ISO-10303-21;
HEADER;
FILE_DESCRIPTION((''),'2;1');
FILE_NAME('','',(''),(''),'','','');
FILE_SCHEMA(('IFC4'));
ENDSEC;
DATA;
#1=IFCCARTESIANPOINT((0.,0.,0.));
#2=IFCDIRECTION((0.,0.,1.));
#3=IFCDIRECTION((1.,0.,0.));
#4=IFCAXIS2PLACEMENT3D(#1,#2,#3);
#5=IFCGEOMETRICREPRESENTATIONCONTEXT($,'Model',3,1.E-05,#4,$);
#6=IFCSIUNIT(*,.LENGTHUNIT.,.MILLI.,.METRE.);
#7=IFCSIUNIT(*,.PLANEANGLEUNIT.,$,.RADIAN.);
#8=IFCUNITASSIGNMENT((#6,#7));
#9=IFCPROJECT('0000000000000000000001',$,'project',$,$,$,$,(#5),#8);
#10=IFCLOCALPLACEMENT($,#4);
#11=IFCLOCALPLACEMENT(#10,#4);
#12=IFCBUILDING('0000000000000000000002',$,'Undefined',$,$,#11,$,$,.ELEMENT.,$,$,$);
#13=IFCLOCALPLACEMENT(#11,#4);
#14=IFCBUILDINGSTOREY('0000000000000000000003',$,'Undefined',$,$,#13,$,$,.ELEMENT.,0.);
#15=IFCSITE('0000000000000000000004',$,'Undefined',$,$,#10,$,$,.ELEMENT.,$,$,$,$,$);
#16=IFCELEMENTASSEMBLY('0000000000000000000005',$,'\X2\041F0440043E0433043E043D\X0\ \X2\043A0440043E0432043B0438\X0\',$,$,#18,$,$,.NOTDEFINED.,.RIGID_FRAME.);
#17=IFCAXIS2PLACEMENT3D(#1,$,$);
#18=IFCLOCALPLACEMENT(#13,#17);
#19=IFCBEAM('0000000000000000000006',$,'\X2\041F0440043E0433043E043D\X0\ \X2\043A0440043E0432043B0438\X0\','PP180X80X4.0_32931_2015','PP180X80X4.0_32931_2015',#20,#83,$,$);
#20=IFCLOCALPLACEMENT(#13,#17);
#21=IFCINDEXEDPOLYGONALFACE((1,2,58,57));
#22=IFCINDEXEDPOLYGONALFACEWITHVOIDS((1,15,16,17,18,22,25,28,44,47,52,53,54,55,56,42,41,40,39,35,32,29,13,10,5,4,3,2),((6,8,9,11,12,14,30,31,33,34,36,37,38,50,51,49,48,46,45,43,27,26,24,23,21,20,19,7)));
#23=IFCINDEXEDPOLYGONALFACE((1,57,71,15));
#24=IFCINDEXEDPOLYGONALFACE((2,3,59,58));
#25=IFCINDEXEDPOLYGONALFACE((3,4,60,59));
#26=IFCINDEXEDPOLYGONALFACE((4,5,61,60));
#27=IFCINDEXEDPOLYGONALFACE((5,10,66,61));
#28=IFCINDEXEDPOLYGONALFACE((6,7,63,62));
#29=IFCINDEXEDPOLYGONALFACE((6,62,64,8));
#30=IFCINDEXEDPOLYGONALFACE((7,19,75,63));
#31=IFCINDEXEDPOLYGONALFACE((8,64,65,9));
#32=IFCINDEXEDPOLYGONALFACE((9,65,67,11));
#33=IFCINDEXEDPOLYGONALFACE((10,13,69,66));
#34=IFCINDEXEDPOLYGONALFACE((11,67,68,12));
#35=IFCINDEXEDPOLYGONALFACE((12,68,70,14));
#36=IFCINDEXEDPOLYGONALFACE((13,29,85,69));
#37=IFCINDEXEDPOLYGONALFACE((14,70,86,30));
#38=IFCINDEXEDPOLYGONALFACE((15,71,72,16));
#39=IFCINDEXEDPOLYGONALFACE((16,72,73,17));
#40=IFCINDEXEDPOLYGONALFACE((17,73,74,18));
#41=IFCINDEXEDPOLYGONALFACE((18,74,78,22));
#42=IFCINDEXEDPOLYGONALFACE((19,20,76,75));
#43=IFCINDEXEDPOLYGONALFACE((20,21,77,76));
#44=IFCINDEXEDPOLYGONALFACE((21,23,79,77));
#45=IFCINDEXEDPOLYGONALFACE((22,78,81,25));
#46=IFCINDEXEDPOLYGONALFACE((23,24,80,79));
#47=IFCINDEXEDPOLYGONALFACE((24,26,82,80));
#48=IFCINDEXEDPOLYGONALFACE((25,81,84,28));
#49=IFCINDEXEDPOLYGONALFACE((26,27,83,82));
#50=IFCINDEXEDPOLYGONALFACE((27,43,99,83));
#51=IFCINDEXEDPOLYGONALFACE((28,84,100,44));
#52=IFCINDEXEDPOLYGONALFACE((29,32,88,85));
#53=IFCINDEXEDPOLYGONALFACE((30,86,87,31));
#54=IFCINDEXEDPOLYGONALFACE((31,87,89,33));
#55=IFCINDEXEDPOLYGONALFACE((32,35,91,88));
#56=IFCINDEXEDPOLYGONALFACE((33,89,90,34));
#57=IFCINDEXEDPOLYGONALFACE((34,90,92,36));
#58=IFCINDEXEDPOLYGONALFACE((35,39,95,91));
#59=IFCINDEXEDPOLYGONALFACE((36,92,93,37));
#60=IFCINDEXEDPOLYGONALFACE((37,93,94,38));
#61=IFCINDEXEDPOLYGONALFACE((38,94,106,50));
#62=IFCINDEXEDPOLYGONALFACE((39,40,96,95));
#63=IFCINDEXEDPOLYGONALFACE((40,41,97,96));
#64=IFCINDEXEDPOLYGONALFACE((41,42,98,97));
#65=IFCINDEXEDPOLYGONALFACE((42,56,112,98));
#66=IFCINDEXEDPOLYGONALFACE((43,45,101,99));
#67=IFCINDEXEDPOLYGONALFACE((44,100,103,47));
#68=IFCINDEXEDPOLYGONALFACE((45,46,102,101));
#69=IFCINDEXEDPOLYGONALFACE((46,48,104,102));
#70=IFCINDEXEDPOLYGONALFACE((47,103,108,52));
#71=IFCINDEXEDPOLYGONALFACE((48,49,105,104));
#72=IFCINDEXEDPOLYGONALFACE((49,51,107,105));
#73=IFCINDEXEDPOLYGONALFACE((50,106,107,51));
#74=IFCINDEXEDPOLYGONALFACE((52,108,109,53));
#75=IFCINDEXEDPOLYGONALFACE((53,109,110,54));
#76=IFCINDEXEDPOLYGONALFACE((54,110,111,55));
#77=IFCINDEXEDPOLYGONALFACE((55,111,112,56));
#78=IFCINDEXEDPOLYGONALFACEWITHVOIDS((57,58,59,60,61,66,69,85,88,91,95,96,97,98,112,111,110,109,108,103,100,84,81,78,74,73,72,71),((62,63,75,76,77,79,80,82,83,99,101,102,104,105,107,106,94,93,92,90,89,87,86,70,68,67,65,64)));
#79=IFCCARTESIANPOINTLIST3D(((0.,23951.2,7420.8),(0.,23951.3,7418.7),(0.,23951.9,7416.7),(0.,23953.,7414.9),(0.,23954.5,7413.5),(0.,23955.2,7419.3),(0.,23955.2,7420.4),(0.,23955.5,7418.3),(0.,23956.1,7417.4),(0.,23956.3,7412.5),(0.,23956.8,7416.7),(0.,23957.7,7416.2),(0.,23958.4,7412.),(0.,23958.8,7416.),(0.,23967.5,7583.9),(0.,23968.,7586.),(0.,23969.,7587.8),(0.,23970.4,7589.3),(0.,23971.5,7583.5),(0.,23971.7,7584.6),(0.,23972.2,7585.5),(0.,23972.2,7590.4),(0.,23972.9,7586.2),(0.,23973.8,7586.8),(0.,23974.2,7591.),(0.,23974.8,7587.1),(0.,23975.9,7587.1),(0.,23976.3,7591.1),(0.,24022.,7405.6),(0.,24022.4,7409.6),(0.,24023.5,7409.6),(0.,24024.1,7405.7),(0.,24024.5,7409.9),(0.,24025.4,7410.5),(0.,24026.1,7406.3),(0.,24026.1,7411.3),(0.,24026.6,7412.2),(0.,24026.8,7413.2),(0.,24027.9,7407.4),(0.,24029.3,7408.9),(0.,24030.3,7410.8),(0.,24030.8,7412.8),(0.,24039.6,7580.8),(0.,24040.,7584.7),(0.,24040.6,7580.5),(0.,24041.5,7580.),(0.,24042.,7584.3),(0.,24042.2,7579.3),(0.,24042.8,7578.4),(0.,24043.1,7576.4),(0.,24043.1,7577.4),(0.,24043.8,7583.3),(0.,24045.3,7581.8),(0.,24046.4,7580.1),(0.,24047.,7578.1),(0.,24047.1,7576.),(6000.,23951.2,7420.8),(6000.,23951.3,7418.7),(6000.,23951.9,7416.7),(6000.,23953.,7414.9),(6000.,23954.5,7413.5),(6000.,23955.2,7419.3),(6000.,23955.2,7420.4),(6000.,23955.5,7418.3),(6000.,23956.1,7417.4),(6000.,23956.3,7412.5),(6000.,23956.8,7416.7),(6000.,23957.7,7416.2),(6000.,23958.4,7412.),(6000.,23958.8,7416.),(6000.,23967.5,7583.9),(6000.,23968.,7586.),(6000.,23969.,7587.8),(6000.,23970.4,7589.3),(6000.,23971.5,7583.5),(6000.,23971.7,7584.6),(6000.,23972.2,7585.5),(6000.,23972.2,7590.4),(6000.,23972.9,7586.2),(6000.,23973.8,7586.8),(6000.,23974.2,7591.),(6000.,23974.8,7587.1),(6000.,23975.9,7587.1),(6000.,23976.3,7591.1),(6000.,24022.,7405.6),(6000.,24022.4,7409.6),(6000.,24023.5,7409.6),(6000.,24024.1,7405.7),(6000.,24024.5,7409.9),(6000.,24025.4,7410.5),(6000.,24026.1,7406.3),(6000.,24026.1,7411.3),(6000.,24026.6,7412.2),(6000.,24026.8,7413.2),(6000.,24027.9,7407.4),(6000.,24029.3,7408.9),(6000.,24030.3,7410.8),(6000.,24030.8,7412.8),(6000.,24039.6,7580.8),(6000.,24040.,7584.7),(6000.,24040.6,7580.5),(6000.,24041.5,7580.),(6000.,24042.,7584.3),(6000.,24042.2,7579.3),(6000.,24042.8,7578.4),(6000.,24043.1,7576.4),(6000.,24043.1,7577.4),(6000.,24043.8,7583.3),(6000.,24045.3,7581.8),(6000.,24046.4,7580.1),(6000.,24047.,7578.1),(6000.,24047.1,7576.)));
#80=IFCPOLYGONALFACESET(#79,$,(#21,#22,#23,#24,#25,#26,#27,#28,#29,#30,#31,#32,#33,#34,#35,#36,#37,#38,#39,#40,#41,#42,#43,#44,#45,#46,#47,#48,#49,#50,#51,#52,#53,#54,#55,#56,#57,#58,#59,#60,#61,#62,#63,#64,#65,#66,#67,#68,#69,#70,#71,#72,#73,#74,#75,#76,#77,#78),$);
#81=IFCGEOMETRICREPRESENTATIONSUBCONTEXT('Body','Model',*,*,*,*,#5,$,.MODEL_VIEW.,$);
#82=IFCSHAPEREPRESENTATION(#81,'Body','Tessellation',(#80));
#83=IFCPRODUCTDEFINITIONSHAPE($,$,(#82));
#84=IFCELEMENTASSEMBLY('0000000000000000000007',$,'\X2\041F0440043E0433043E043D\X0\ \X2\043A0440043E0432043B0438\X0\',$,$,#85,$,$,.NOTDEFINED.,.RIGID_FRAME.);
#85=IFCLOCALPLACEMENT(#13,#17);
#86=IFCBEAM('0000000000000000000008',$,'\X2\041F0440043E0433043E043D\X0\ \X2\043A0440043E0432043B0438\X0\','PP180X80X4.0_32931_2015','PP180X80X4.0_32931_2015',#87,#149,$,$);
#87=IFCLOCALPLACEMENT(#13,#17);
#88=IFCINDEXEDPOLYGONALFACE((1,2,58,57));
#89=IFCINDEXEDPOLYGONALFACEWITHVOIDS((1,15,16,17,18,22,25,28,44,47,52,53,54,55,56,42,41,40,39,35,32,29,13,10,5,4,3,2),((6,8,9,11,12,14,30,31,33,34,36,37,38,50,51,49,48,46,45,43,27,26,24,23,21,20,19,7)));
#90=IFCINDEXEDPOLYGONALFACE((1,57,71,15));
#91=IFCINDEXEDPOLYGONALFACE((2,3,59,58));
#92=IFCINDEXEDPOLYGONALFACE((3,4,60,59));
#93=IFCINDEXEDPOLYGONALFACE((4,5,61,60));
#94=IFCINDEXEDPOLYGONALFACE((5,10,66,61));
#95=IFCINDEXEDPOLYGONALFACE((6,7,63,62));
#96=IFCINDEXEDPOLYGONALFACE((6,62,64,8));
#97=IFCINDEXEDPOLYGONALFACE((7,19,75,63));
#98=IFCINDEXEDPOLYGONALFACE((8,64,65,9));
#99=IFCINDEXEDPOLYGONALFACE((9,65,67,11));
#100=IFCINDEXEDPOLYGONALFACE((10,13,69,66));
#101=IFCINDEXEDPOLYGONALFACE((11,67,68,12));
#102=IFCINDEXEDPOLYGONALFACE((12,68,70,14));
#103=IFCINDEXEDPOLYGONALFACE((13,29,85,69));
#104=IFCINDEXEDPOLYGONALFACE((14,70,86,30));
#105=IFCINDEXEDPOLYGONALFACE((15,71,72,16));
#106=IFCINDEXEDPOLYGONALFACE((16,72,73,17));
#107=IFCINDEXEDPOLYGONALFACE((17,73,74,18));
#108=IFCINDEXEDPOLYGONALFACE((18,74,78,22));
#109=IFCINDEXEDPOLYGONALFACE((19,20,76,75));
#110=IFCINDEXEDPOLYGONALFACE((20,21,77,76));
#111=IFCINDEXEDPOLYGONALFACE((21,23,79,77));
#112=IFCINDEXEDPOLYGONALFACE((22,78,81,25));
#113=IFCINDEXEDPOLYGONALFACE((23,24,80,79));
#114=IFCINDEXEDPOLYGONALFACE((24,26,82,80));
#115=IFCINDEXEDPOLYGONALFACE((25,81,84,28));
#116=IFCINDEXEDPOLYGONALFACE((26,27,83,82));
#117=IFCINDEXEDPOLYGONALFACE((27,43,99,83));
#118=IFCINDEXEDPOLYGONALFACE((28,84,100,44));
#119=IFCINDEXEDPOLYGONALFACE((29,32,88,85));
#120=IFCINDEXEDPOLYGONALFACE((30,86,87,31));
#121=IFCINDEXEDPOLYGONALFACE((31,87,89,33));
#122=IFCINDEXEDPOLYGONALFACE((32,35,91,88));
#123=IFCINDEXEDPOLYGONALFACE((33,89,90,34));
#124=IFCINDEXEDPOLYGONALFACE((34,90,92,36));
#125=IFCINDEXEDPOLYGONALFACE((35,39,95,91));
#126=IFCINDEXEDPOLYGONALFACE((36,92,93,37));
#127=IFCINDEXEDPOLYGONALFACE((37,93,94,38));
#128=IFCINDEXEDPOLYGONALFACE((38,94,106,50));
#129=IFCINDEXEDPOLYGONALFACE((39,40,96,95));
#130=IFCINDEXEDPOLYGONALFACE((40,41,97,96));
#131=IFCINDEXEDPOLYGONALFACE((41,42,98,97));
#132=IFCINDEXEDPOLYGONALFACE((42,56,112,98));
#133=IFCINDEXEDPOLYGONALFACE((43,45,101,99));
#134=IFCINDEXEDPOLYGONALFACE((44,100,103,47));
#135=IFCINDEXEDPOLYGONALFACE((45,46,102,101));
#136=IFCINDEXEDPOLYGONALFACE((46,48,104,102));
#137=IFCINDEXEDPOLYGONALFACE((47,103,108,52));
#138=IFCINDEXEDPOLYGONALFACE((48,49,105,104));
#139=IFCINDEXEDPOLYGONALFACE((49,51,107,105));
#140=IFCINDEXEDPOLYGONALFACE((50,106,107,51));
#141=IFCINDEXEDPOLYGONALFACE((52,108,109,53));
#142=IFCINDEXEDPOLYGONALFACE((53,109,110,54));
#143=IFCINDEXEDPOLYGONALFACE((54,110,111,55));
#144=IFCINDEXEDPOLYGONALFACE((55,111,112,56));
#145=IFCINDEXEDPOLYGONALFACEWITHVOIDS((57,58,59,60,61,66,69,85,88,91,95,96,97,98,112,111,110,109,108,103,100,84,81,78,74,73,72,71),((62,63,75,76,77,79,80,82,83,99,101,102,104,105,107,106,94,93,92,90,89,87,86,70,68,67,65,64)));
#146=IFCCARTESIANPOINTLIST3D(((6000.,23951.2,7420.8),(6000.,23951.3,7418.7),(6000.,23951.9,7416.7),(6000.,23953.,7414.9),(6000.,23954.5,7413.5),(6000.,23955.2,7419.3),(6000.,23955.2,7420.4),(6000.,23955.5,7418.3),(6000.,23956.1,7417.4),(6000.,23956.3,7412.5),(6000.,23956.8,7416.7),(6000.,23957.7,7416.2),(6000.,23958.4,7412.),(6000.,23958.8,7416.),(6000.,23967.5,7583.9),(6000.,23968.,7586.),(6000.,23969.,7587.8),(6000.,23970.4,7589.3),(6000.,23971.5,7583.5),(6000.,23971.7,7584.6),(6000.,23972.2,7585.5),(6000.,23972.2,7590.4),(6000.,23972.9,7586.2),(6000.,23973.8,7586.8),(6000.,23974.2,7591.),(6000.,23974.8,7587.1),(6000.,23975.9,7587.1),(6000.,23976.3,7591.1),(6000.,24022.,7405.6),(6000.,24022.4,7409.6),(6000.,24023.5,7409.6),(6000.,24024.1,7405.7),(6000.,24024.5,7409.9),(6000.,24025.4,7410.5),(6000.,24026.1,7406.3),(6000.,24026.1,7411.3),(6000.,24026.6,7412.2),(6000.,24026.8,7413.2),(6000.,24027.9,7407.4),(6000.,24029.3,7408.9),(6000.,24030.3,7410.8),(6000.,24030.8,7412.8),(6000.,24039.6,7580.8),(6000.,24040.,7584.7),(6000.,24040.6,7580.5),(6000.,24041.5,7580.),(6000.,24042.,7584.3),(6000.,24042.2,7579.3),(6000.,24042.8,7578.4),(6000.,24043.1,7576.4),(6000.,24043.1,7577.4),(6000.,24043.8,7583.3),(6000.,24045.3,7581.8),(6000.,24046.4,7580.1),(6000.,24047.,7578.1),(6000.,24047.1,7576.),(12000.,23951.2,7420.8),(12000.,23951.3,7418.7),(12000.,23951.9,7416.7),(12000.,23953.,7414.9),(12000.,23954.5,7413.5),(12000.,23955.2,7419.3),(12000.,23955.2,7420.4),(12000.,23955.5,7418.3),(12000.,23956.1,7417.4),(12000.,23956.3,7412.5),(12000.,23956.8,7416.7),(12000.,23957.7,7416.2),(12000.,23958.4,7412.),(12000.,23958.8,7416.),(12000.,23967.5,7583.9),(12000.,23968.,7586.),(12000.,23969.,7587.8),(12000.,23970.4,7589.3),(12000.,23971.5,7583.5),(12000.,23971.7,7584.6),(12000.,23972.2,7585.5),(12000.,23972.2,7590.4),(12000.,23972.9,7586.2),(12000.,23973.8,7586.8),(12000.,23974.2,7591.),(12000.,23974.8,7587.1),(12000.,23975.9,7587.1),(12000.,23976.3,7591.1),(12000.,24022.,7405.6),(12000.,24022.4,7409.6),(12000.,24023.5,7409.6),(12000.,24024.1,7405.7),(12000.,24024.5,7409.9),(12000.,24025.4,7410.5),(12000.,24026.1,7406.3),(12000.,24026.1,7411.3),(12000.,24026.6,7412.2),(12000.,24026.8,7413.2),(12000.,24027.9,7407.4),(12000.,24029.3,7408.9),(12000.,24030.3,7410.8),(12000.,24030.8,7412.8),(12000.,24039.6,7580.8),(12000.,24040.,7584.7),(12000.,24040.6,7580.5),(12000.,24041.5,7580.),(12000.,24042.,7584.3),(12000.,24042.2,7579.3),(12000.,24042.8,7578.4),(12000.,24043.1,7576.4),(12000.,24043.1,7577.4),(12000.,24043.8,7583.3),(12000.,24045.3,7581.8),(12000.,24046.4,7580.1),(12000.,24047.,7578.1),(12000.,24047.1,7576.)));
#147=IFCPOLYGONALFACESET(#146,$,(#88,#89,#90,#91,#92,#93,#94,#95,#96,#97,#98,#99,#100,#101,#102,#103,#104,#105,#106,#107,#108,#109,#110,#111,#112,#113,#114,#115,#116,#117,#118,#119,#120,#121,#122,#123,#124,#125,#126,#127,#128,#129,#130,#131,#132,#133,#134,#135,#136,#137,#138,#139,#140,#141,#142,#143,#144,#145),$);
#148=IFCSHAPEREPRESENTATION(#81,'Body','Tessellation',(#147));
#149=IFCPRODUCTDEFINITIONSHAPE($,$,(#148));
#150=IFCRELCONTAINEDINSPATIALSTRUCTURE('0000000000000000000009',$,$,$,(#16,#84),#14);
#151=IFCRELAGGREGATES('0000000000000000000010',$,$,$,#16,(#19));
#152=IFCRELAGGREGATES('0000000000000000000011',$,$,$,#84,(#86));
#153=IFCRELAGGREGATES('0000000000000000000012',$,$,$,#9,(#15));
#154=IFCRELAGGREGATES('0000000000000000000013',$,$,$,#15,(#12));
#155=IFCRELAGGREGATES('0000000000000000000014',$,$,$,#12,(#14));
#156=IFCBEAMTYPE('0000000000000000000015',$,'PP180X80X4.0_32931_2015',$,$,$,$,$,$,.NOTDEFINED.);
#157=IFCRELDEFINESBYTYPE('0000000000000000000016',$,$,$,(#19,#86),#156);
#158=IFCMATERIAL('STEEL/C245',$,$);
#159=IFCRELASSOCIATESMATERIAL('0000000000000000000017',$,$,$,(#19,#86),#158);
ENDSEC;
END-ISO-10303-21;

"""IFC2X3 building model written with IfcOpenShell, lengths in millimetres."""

from ifc_helpers import new_model, si_unit, frame, origin_with_axes, origin_2d_with_axis, place, context, subcontext, project, spatial, hollow_rectangle, extrude, material, type_object, element, aggregate, save


model = new_model("IFC2X3")

# Units and contexts
model_context = context("Model", 3, precision=1e-05, world=origin_with_axes())
body_context = subcontext(model_context, "Body", "Model", "MODEL_VIEW")
ifc_project = project(units=[si_unit("LENGTHUNIT", "METRE", prefix="MILLI"), si_unit("PLANEANGLEUNIT", "RADIAN")], contexts=[model_context])

# Site, building, storey
site_placement = place(None, origin_with_axes())
site = spatial("IfcSite", under=ifc_project, at=site_placement, Name="Undefined", CompositionType="ELEMENT")
building_placement = place(site_placement, origin_with_axes())
building = spatial("IfcBuilding", under=site, at=building_placement, Name="Undefined", CompositionType="ELEMENT")
storey_placement = place(building_placement, origin_with_axes())
storey = spatial("IfcBuildingStorey", under=building, at=storey_placement, Name="Undefined", CompositionType="ELEMENT", Elevation=0.0)

# Shared definitions
ifc_material_1 = material(Name="STEEL/C245")

# Element assemblies, beams
assembly_1_placement = place(storey_placement, origin_with_axes())
assembly_1 = element("IfcElementAssembly", 1, at=assembly_1_placement, inside=storey, Name="Прогон кровли", AssemblyPlace="NOTDEFINED", PredefinedType="RIGID_FRAME")
beam_type_1 = type_object("IfcBeamType", Name="PP180X80X4.0_32931_2015", PredefinedType="NOTDEFINED")
beam_1_placement = place(assembly_1_placement, frame((0.0, 23999.2, 7498.4), z_axis=(0.0, 0.099504, 0.995037), x_axis=(1.0, 0.0, 0.0)))
beam_1 = element("IfcBeam", 2, at=beam_1_placement, type_object=beam_type_1, material=ifc_material_1, Name="Прогон кровли", Description="PP180X80X4.0_32931_2015", ObjectType="PP180X80X4.0_32931_2015", context=body_context, shape_type="SweptSolid", body=[
    extrude(hollow_rectangle(XDim=80.0, YDim=180.0, WallThickness=4.0, InnerFilletRadius=4.0, OuterFilletRadius=8.0, at=origin_2d_with_axis()), frame((6000.0, 0.0, 0.0), z_axis=(-1.0, 0.0, 0.0), x_axis=(0.0, -1.0, 0.0)), (0.0, 0.0, 1.0), 6000.0),
])
aggregate(assembly_1, [beam_1])
assembly_2_placement = place(storey_placement, origin_with_axes())
assembly_2 = element("IfcElementAssembly", 3, at=assembly_2_placement, inside=storey, Name="Прогон кровли", AssemblyPlace="NOTDEFINED", PredefinedType="RIGID_FRAME")
beam_2_placement = place(assembly_2_placement, frame((6000.0, 23999.2, 7498.4), z_axis=(0.0, 0.099504, 0.995037), x_axis=(1.0, 0.0, 0.0)))
beam_2 = element("IfcBeam", 4, at=beam_2_placement, type_object=beam_type_1, material=ifc_material_1, Name="Прогон кровли", Description="PP180X80X4.0_32931_2015", ObjectType="PP180X80X4.0_32931_2015", context=body_context, shape_type="SweptSolid", body=[
    extrude(hollow_rectangle(XDim=80.0, YDim=180.0, WallThickness=4.0, InnerFilletRadius=4.0, OuterFilletRadius=8.0, at=origin_2d_with_axis()), frame((6000.0, 0.0, 0.0), z_axis=(-1.0, 0.0, 0.0), x_axis=(0.0, -1.0, 0.0)), (0.0, 0.0, 1.0), 6000.0),
])
aggregate(assembly_2, [beam_2])

save(model, "model.ifc")
